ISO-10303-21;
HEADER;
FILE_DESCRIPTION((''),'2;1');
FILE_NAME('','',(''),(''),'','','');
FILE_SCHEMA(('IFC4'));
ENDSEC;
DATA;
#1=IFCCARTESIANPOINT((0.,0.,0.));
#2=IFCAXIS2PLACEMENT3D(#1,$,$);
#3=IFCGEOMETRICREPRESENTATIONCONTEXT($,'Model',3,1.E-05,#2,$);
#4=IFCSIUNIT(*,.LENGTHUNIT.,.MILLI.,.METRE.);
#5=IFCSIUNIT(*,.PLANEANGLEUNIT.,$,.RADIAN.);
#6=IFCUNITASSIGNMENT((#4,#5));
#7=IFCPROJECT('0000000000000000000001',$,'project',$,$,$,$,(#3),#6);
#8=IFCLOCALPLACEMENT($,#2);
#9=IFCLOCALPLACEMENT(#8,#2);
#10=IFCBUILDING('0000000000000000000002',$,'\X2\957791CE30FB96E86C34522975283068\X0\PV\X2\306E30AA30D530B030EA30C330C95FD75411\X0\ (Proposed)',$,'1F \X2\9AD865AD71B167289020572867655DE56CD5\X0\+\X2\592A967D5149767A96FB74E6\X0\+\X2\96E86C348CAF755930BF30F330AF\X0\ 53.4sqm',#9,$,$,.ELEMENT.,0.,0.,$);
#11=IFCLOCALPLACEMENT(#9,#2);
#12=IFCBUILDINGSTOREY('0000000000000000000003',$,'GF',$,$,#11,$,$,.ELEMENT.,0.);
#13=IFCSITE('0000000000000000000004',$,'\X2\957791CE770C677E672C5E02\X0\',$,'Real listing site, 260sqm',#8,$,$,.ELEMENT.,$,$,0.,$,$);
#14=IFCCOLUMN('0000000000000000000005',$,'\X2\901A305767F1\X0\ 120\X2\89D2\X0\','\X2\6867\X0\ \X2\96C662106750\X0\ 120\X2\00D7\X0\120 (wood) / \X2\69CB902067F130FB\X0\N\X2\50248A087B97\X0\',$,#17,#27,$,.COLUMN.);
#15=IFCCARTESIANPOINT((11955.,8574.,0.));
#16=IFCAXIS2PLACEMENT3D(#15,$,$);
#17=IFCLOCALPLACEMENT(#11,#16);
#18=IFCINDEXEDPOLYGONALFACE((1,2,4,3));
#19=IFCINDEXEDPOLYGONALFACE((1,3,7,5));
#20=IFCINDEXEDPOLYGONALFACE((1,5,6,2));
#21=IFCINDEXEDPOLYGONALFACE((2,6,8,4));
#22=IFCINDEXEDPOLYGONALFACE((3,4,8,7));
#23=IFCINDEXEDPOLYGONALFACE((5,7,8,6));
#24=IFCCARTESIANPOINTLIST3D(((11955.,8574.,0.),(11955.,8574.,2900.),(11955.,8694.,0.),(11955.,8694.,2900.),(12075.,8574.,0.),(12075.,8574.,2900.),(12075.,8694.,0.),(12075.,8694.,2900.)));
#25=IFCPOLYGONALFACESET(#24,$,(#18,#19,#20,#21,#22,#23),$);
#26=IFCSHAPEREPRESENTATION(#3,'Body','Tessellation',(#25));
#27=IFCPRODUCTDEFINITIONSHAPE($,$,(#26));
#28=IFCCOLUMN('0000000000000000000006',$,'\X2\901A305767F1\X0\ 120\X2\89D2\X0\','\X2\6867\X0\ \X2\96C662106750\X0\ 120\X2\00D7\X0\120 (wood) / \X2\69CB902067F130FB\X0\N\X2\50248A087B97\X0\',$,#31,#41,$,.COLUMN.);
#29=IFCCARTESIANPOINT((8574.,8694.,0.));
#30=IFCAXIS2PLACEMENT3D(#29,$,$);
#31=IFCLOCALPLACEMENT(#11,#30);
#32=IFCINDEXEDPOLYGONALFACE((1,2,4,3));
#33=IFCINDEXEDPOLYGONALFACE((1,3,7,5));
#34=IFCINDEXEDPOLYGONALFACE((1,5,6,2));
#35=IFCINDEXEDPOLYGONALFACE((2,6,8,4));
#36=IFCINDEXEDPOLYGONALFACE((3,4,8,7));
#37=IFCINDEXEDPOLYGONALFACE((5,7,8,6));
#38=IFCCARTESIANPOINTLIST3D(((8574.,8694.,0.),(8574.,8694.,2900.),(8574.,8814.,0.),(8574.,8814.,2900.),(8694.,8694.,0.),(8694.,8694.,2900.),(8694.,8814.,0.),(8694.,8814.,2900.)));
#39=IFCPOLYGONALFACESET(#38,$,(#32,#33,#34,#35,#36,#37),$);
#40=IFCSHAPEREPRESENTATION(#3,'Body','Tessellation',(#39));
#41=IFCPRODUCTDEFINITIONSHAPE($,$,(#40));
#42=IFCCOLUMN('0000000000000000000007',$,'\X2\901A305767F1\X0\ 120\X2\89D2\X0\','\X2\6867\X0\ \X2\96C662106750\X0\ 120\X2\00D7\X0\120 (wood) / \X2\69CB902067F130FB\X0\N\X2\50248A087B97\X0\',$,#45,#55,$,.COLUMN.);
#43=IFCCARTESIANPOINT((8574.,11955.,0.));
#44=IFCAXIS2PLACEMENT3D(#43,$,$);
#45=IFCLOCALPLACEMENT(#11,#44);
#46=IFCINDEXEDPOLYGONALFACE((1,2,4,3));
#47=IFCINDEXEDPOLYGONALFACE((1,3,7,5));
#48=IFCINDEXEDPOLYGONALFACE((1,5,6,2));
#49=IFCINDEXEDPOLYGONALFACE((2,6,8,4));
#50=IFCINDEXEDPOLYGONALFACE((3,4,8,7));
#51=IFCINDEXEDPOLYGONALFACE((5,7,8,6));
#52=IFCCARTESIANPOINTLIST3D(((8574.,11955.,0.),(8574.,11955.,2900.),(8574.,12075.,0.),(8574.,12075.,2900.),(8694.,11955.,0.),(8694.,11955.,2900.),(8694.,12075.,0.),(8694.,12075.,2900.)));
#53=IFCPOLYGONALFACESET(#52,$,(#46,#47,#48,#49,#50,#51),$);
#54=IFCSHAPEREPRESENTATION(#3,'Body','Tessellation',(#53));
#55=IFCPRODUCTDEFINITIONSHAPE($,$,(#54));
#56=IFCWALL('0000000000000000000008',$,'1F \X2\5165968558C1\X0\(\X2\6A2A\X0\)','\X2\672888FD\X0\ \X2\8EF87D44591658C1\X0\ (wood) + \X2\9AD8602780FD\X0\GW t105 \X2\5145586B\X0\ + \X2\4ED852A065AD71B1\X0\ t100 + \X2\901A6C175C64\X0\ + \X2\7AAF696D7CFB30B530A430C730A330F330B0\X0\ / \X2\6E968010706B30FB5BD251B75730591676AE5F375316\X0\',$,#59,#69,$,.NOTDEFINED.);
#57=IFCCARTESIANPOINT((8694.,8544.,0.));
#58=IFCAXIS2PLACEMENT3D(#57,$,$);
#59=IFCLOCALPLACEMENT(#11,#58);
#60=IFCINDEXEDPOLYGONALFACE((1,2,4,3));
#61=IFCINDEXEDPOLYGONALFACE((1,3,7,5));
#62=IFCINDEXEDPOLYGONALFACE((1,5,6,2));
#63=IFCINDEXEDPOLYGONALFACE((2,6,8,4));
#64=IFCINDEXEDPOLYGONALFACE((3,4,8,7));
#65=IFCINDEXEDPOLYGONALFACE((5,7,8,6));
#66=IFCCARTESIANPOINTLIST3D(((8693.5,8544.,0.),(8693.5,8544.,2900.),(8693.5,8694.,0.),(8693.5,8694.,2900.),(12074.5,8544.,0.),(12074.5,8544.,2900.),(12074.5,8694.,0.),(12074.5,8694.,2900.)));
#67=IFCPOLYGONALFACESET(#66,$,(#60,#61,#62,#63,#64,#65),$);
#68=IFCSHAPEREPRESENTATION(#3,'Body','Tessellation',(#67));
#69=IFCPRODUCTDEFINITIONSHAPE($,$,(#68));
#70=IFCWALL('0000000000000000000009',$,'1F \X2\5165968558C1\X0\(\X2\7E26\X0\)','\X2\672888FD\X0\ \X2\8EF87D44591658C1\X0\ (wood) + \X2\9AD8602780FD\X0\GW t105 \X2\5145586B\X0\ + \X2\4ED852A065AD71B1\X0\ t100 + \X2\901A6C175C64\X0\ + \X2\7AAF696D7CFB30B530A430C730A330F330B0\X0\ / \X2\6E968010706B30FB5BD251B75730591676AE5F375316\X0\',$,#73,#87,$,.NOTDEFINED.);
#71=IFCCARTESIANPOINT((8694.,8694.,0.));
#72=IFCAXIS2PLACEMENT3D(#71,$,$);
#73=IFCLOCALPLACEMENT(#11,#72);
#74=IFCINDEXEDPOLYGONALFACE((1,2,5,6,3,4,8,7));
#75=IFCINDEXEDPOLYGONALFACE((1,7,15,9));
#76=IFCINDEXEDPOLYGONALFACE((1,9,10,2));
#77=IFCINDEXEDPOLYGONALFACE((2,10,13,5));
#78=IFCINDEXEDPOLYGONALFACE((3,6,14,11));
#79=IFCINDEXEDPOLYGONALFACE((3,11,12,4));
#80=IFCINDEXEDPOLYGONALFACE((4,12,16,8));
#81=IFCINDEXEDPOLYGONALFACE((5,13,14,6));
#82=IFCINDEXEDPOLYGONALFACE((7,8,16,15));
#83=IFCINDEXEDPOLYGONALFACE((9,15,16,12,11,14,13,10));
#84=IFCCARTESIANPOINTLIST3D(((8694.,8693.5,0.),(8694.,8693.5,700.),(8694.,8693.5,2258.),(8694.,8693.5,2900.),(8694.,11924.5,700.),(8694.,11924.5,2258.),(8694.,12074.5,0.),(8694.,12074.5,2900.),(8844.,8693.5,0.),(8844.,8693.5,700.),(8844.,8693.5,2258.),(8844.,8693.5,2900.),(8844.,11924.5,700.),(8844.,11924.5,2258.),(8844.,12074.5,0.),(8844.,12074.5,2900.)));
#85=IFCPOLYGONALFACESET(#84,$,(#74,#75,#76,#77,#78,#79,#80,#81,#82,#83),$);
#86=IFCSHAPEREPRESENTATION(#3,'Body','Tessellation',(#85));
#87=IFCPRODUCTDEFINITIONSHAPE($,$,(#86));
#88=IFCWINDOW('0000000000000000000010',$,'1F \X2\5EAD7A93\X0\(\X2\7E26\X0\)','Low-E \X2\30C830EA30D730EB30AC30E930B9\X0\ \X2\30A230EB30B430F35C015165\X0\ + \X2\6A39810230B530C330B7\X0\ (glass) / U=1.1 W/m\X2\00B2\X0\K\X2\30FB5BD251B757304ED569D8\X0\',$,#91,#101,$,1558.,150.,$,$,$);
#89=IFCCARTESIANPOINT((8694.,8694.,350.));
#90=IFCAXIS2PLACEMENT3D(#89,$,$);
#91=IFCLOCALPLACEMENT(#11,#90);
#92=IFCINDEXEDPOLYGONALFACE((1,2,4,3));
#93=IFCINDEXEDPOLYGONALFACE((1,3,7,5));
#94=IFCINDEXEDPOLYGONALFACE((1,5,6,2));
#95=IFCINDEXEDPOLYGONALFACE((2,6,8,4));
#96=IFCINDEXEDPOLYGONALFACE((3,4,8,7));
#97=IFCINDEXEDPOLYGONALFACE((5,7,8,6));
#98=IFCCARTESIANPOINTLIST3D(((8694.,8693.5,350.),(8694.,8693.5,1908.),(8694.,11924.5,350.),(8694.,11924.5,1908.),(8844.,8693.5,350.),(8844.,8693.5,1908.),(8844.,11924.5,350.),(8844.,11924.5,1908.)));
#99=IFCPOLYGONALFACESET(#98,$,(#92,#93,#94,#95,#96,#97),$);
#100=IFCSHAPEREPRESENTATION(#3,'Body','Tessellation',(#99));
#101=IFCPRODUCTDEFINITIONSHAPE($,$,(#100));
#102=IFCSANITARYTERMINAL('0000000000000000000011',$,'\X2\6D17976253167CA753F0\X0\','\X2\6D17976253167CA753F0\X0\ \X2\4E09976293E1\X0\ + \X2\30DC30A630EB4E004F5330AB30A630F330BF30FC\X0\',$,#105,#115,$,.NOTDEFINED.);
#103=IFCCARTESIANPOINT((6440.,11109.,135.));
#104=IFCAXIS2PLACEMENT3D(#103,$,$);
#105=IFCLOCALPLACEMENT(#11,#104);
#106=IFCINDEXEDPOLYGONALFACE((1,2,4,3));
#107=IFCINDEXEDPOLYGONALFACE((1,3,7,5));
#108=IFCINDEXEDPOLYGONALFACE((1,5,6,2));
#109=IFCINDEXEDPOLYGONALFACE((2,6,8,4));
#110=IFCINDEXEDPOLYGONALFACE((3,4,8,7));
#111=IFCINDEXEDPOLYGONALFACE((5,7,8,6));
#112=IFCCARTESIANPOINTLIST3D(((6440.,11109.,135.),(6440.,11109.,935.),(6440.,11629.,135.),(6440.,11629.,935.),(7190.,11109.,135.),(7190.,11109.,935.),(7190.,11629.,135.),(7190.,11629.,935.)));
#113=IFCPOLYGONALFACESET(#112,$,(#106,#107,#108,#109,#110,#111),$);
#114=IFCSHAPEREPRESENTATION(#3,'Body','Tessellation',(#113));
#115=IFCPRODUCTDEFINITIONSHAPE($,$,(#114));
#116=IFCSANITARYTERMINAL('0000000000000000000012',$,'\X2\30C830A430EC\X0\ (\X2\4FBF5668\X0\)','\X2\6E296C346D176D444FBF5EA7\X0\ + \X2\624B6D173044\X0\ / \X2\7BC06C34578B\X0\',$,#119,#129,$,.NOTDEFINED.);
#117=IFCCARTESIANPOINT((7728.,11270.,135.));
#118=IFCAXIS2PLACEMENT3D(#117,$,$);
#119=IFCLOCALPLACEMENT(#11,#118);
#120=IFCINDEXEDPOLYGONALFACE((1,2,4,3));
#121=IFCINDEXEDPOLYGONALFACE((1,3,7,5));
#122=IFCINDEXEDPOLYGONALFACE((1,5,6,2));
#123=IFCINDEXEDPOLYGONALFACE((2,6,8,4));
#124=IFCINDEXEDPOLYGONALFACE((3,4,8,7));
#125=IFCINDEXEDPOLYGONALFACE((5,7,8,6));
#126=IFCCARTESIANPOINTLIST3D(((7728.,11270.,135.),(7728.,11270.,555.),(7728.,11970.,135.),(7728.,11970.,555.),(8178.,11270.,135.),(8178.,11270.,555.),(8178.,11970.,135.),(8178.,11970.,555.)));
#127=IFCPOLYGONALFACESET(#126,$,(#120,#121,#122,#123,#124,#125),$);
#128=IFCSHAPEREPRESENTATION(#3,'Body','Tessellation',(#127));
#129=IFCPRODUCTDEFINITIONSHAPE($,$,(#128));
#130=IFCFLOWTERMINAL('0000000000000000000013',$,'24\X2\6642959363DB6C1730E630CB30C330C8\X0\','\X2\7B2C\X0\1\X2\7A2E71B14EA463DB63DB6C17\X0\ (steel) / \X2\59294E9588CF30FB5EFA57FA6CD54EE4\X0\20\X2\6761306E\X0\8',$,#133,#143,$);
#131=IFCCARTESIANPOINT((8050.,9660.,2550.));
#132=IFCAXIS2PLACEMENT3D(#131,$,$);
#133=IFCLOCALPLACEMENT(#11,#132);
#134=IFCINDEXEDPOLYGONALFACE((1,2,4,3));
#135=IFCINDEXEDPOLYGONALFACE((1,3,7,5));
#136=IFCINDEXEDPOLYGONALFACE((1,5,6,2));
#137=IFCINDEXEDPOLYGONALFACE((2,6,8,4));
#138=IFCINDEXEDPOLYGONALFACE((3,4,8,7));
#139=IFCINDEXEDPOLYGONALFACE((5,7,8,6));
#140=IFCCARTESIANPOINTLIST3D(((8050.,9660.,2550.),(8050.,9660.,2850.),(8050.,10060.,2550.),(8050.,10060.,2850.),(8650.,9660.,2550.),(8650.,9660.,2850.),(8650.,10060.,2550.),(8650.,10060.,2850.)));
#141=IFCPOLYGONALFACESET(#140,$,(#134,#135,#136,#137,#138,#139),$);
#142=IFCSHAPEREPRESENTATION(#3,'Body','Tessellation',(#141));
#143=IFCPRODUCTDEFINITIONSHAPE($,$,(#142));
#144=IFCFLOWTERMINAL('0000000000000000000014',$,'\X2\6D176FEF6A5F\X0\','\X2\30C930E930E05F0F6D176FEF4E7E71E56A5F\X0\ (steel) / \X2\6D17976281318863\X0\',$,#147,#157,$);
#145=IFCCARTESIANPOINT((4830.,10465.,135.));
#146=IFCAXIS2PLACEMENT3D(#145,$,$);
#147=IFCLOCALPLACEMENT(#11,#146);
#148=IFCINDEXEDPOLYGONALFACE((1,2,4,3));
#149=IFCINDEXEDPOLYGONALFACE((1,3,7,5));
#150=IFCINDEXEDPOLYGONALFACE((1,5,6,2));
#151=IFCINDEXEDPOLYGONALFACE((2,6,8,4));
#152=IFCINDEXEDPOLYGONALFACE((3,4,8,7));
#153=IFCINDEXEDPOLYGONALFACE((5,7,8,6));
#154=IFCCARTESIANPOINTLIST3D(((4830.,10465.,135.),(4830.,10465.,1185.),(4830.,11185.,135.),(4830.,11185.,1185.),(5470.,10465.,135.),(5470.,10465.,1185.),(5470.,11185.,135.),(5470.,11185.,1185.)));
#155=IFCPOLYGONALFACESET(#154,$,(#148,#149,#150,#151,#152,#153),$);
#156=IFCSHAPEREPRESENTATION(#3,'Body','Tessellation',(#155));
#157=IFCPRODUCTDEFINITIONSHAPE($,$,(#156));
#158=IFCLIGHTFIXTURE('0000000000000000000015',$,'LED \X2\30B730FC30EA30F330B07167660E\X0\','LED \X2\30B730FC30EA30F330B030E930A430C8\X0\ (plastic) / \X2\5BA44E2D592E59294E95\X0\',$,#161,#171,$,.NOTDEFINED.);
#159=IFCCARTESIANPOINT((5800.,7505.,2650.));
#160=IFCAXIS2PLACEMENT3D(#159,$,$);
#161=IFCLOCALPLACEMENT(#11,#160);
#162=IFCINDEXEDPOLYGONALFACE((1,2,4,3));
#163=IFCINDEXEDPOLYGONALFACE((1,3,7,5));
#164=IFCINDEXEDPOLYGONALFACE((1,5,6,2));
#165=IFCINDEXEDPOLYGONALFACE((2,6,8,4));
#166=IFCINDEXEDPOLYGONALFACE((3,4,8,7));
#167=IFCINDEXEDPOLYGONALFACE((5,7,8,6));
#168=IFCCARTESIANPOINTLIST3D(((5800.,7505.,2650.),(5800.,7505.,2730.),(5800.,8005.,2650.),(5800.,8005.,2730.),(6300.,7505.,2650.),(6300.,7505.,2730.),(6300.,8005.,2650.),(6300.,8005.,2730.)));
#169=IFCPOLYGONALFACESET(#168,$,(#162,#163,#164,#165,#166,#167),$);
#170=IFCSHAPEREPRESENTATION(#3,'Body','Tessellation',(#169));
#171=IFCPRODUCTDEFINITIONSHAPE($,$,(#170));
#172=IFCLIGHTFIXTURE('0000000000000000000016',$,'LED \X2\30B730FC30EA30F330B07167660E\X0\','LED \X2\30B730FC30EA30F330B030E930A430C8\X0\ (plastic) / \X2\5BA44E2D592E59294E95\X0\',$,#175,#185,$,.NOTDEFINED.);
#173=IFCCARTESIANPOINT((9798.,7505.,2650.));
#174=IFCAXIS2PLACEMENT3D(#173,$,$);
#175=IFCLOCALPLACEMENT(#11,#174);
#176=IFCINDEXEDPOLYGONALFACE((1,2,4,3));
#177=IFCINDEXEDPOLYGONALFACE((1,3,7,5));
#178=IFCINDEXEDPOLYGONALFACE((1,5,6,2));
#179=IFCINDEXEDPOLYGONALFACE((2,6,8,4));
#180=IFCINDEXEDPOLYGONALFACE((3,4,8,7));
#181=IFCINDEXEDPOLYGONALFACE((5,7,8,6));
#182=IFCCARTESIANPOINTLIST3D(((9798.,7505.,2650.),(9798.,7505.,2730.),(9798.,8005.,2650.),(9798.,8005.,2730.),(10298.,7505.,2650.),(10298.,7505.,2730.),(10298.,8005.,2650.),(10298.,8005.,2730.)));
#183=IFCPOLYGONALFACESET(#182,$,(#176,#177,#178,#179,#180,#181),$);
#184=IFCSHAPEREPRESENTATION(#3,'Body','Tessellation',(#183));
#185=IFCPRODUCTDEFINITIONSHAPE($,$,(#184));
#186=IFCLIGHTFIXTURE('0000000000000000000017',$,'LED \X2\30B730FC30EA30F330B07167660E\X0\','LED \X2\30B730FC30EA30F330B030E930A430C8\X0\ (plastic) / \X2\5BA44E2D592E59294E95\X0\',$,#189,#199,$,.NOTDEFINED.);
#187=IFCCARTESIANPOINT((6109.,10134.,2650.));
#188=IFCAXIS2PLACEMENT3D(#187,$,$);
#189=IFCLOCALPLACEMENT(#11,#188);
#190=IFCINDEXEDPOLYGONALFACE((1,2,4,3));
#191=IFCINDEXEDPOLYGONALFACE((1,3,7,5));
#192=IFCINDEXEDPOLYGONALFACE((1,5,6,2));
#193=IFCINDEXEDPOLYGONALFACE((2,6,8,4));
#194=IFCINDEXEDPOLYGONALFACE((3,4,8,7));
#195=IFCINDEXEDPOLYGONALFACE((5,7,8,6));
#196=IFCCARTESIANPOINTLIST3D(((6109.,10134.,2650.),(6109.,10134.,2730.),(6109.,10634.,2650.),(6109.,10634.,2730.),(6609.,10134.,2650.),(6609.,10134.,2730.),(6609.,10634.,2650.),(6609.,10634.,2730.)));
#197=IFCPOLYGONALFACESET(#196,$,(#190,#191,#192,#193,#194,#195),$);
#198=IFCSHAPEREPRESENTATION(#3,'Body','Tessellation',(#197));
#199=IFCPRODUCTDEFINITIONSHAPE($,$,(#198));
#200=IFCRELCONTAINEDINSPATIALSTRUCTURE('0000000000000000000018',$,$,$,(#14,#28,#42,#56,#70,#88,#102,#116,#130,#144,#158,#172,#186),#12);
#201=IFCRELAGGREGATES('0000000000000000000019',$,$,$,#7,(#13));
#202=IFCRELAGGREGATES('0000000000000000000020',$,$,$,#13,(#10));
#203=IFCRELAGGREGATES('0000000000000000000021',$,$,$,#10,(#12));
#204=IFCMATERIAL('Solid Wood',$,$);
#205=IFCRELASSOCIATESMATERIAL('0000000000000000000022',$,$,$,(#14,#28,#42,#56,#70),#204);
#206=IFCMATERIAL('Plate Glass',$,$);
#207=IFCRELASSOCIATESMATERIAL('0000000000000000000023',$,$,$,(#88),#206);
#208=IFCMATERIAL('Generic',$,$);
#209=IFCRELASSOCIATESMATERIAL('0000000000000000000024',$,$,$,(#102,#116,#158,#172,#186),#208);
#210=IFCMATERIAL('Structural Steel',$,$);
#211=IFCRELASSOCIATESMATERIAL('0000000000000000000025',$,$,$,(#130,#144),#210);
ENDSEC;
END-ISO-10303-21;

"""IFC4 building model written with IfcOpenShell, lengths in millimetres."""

from ifc_helpers import new_model, si_unit, frame, frame_2d, origin, place, context, project, spatial, rectangle, extrude, material, element, fill, save


model = new_model("IFC4")

# Units and contexts
model_context = context("Model", 3, precision=1e-05, world=origin())
ifc_project = project(units=[si_unit("LENGTHUNIT", "METRE", prefix="MILLI"), si_unit("PLANEANGLEUNIT", "RADIAN")], contexts=[model_context])

# Site, building, storey
site_placement = place(None, origin())
site = spatial("IfcSite", under=ifc_project, at=site_placement, Name="長野県松本市", ObjectType="Real listing site, 260sqm", CompositionType="ELEMENT", RefElevation=0.0)
building_placement = place(site_placement, origin())
building = spatial("IfcBuilding", under=site, at=building_placement, Name="長野・雨水利用とPVのオフグリッド志向 (Proposed)", ObjectType="1F 高断熱木造在来工法+太陽光発電瓦+雨水貯留タンク 53.4sqm", CompositionType="ELEMENT", ElevationOfRefHeight=0.0, ElevationOfTerrain=0.0)
storey_placement = place(building_placement, origin())
storey = spatial("IfcBuildingStorey", under=building, at=storey_placement, Name="GF", CompositionType="ELEMENT", Elevation=0.0)

# Columns
ifc_material_1 = material(Name="Solid Wood")
column_1_placement = place(storey_placement, frame((11955.0, 8574.0, 0.0)))
element("IfcColumn", 1, at=column_1_placement, inside=storey, material=ifc_material_1, Name="通し柱 120角", Description="桧 集成材 120×120 (wood) / 構造柱・N値計算", PredefinedType="COLUMN", context=model_context, shape_type="SweptSolid", body=[
    extrude(rectangle(XDim=120.0, YDim=120.0, at=frame_2d((60.0, 60.0))), frame((11955.0, 8574.0, 0.0)), (0.0, 0.0, 1.0), 2900.0),
])
column_2_placement = place(storey_placement, frame((8574.0, 8694.0, 0.0)))
element("IfcColumn", 2, at=column_2_placement, inside=storey, material=ifc_material_1, Name="通し柱 120角", Description="桧 集成材 120×120 (wood) / 構造柱・N値計算", PredefinedType="COLUMN", context=model_context, shape_type="SweptSolid", body=[
    extrude(rectangle(XDim=120.0, YDim=120.0, at=frame_2d((60.0, 60.0))), frame((8574.0, 8694.0, 0.0)), (0.0, 0.0, 1.0), 2900.0),
])
column_3_placement = place(storey_placement, frame((8574.0, 11955.0, 0.0)))
element("IfcColumn", 3, at=column_3_placement, inside=storey, material=ifc_material_1, Name="通し柱 120角", Description="桧 集成材 120×120 (wood) / 構造柱・N値計算", PredefinedType="COLUMN", context=model_context, shape_type="SweptSolid", body=[
    extrude(rectangle(XDim=120.0, YDim=120.0, at=frame_2d((60.0, 60.0))), frame((8574.0, 11955.0, 0.0)), (0.0, 0.0, 1.0), 2900.0),
])

# Wall
wall_1_placement = place(storey_placement, frame((8694.0, 8544.0, 0.0)))
element("IfcWall", 4, at=wall_1_placement, inside=storey, material=ifc_material_1, Name="1F 入隅壁(横)", Description="木製 軸組外壁 (wood) + 高性能GW t105 充填 + 付加断熱 t100 + 通気層 + 窯業系サイディング / 準耐火・寒冷地外皮強化", PredefinedType="NOTDEFINED", context=model_context, shape_type="SweptSolid", body=[
    extrude(rectangle(XDim=3381.0, YDim=150.0, at=frame_2d((1690.0, 75.0))), frame((8694.0, 8544.0, 0.0)), (0.0, 0.0, 1.0), 2900.0),
])

# Wall, opening, window
wall_2_placement = place(storey_placement, frame((8694.0, 8694.0, 0.0)))
wall_2 = element("IfcWall", 5, at=wall_2_placement, inside=storey, material=ifc_material_1, Name="1F 入隅壁(縦)", Description="木製 軸組外壁 (wood) + 高性能GW t105 充填 + 付加断熱 t100 + 通気層 + 窯業系サイディング / 準耐火・寒冷地外皮強化", PredefinedType="NOTDEFINED", context=model_context, shape_type="SweptSolid", body=[
    extrude(rectangle(XDim=150.0, YDim=3381.0, at=frame_2d((75.0, 1690.0))), frame((8694.0, 8694.0, 0.0)), (0.0, 0.0, 1.0), 2900.0),
])
opening_placement = place(storey_placement, frame((8694.0, 8694.0, 350.0)))
opening = element("IfcOpeningElement", 6, at=opening_placement, cuts=wall_2, PredefinedType="NOTDEFINED", context=model_context, shape_type="SweptSolid", body=[
    extrude(rectangle(XDim=150.0, YDim=3231.0, at=frame_2d((75.0, 1615.0))), frame((8694.0, 8694.0, 350.0)), (0.0, 0.0, 1.0), 1558.0),
])
ifc_material_2 = material(Name="Plate Glass")
window_placement = place(storey_placement, frame((8694.0, 8694.0, 350.0)))
window = element("IfcWindow", 7, at=window_placement, inside=storey, material=ifc_material_2, Name="1F 庭窓(縦)", Description="Low-E トリプルガラス アルゴン封入 + 樹脂サッシ (glass) / U=1.1 W/m²K・寒冷地仕様", OverallHeight=1558.0, OverallWidth=150.0, context=model_context, shape_type="SweptSolid", body=[
    extrude(rectangle(XDim=150.0, YDim=3231.0, at=frame_2d((75.0, 1615.0))), frame((8694.0, 8694.0, 350.0)), (0.0, 0.0, 1.0), 1558.0),
])
fill(opening, window)

# Sanitary terminals
ifc_material_3 = material(Name="Generic")
sanitary_terminal_1_placement = place(storey_placement, frame((6440.0, 11109.0, 135.0)))
element("IfcSanitaryTerminal", 8, at=sanitary_terminal_1_placement, inside=storey, material=ifc_material_3, Name="洗面化粧台", Description="洗面化粧台 三面鏡 + ボウル一体カウンター", PredefinedType="NOTDEFINED", context=model_context, shape_type="SweptSolid", body=[
    extrude(rectangle(XDim=750.0, YDim=520.0, at=frame_2d((375.0, 260.0))), frame((6440.0, 11109.0, 135.0)), (0.0, 0.0, 1.0), 800.0),
])
sanitary_terminal_2_placement = place(storey_placement, frame((7728.0, 11270.0, 135.0)))
element("IfcSanitaryTerminal", 9, at=sanitary_terminal_2_placement, inside=storey, material=ifc_material_3, Name="トイレ (便器)", Description="温水洗浄便座 + 手洗い / 節水型", PredefinedType="NOTDEFINED", context=model_context, shape_type="SweptSolid", body=[
    extrude(rectangle(XDim=450.0, YDim=700.0, at=frame_2d((225.0, 350.0))), frame((7728.0, 11270.0, 135.0)), (0.0, 0.0, 1.0), 420.0),
])

# Flow terminals
ifc_material_4 = material(Name="Structural Steel")
flow_terminal_1_placement = place(storey_placement, frame((8050.0, 9660.0, 2550.0)))
element("IfcFlowTerminal", 10, at=flow_terminal_1_placement, inside=storey, material=ifc_material_4, Name="24時間換気ユニット", Description="第1種熱交換換気 (steel) / 天井裏・建基法令20条の8", context=model_context, shape_type="SweptSolid", body=[
    extrude(rectangle(XDim=600.0, YDim=400.0, at=frame_2d((300.0, 200.0))), frame((8050.0, 9660.0, 2550.0)), (0.0, 0.0, 1.0), 300.0),
])
flow_terminal_2_placement = place(storey_placement, frame((4830.0, 10465.0, 135.0)))
element("IfcFlowTerminal", 11, at=flow_terminal_2_placement, inside=storey, material=ifc_material_4, Name="洗濯機", Description="ドラム式洗濯乾燥機 (steel) / 洗面脱衣", context=model_context, shape_type="SweptSolid", body=[
    extrude(rectangle(XDim=640.0, YDim=720.0, at=frame_2d((320.0, 360.0))), frame((4830.0, 10465.0, 135.0)), (0.0, 0.0, 1.0), 1050.0),
])

# Light fixtures
light_fixture_1_placement = place(storey_placement, frame((5800.0, 7505.0, 2650.0)))
element("IfcLightFixture", 12, at=light_fixture_1_placement, inside=storey, material=ifc_material_3, Name="LED シーリング照明", Description="LED シーリングライト (plastic) / 室中央天井", PredefinedType="NOTDEFINED", context=model_context, shape_type="SweptSolid", body=[
    extrude(rectangle(XDim=500.0, YDim=500.0, at=frame_2d((250.0, 250.0))), frame((5800.0, 7505.0, 2650.0)), (0.0, 0.0, 1.0), 80.0),
])
light_fixture_2_placement = place(storey_placement, frame((9798.0, 7505.0, 2650.0)))
element("IfcLightFixture", 13, at=light_fixture_2_placement, inside=storey, material=ifc_material_3, Name="LED シーリング照明", Description="LED シーリングライト (plastic) / 室中央天井", PredefinedType="NOTDEFINED", context=model_context, shape_type="SweptSolid", body=[
    extrude(rectangle(XDim=500.0, YDim=500.0, at=frame_2d((250.0, 250.0))), frame((9798.0, 7505.0, 2650.0)), (0.0, 0.0, 1.0), 80.0),
])
light_fixture_3_placement = place(storey_placement, frame((6109.0, 10134.0, 2650.0)))
element("IfcLightFixture", 14, at=light_fixture_3_placement, inside=storey, material=ifc_material_3, Name="LED シーリング照明", Description="LED シーリングライト (plastic) / 室中央天井", PredefinedType="NOTDEFINED", context=model_context, shape_type="SweptSolid", body=[
    extrude(rectangle(XDim=500.0, YDim=500.0, at=frame_2d((250.0, 250.0))), frame((6109.0, 10134.0, 2650.0)), (0.0, 0.0, 1.0), 80.0),
])

save(model, "model.ifc")
